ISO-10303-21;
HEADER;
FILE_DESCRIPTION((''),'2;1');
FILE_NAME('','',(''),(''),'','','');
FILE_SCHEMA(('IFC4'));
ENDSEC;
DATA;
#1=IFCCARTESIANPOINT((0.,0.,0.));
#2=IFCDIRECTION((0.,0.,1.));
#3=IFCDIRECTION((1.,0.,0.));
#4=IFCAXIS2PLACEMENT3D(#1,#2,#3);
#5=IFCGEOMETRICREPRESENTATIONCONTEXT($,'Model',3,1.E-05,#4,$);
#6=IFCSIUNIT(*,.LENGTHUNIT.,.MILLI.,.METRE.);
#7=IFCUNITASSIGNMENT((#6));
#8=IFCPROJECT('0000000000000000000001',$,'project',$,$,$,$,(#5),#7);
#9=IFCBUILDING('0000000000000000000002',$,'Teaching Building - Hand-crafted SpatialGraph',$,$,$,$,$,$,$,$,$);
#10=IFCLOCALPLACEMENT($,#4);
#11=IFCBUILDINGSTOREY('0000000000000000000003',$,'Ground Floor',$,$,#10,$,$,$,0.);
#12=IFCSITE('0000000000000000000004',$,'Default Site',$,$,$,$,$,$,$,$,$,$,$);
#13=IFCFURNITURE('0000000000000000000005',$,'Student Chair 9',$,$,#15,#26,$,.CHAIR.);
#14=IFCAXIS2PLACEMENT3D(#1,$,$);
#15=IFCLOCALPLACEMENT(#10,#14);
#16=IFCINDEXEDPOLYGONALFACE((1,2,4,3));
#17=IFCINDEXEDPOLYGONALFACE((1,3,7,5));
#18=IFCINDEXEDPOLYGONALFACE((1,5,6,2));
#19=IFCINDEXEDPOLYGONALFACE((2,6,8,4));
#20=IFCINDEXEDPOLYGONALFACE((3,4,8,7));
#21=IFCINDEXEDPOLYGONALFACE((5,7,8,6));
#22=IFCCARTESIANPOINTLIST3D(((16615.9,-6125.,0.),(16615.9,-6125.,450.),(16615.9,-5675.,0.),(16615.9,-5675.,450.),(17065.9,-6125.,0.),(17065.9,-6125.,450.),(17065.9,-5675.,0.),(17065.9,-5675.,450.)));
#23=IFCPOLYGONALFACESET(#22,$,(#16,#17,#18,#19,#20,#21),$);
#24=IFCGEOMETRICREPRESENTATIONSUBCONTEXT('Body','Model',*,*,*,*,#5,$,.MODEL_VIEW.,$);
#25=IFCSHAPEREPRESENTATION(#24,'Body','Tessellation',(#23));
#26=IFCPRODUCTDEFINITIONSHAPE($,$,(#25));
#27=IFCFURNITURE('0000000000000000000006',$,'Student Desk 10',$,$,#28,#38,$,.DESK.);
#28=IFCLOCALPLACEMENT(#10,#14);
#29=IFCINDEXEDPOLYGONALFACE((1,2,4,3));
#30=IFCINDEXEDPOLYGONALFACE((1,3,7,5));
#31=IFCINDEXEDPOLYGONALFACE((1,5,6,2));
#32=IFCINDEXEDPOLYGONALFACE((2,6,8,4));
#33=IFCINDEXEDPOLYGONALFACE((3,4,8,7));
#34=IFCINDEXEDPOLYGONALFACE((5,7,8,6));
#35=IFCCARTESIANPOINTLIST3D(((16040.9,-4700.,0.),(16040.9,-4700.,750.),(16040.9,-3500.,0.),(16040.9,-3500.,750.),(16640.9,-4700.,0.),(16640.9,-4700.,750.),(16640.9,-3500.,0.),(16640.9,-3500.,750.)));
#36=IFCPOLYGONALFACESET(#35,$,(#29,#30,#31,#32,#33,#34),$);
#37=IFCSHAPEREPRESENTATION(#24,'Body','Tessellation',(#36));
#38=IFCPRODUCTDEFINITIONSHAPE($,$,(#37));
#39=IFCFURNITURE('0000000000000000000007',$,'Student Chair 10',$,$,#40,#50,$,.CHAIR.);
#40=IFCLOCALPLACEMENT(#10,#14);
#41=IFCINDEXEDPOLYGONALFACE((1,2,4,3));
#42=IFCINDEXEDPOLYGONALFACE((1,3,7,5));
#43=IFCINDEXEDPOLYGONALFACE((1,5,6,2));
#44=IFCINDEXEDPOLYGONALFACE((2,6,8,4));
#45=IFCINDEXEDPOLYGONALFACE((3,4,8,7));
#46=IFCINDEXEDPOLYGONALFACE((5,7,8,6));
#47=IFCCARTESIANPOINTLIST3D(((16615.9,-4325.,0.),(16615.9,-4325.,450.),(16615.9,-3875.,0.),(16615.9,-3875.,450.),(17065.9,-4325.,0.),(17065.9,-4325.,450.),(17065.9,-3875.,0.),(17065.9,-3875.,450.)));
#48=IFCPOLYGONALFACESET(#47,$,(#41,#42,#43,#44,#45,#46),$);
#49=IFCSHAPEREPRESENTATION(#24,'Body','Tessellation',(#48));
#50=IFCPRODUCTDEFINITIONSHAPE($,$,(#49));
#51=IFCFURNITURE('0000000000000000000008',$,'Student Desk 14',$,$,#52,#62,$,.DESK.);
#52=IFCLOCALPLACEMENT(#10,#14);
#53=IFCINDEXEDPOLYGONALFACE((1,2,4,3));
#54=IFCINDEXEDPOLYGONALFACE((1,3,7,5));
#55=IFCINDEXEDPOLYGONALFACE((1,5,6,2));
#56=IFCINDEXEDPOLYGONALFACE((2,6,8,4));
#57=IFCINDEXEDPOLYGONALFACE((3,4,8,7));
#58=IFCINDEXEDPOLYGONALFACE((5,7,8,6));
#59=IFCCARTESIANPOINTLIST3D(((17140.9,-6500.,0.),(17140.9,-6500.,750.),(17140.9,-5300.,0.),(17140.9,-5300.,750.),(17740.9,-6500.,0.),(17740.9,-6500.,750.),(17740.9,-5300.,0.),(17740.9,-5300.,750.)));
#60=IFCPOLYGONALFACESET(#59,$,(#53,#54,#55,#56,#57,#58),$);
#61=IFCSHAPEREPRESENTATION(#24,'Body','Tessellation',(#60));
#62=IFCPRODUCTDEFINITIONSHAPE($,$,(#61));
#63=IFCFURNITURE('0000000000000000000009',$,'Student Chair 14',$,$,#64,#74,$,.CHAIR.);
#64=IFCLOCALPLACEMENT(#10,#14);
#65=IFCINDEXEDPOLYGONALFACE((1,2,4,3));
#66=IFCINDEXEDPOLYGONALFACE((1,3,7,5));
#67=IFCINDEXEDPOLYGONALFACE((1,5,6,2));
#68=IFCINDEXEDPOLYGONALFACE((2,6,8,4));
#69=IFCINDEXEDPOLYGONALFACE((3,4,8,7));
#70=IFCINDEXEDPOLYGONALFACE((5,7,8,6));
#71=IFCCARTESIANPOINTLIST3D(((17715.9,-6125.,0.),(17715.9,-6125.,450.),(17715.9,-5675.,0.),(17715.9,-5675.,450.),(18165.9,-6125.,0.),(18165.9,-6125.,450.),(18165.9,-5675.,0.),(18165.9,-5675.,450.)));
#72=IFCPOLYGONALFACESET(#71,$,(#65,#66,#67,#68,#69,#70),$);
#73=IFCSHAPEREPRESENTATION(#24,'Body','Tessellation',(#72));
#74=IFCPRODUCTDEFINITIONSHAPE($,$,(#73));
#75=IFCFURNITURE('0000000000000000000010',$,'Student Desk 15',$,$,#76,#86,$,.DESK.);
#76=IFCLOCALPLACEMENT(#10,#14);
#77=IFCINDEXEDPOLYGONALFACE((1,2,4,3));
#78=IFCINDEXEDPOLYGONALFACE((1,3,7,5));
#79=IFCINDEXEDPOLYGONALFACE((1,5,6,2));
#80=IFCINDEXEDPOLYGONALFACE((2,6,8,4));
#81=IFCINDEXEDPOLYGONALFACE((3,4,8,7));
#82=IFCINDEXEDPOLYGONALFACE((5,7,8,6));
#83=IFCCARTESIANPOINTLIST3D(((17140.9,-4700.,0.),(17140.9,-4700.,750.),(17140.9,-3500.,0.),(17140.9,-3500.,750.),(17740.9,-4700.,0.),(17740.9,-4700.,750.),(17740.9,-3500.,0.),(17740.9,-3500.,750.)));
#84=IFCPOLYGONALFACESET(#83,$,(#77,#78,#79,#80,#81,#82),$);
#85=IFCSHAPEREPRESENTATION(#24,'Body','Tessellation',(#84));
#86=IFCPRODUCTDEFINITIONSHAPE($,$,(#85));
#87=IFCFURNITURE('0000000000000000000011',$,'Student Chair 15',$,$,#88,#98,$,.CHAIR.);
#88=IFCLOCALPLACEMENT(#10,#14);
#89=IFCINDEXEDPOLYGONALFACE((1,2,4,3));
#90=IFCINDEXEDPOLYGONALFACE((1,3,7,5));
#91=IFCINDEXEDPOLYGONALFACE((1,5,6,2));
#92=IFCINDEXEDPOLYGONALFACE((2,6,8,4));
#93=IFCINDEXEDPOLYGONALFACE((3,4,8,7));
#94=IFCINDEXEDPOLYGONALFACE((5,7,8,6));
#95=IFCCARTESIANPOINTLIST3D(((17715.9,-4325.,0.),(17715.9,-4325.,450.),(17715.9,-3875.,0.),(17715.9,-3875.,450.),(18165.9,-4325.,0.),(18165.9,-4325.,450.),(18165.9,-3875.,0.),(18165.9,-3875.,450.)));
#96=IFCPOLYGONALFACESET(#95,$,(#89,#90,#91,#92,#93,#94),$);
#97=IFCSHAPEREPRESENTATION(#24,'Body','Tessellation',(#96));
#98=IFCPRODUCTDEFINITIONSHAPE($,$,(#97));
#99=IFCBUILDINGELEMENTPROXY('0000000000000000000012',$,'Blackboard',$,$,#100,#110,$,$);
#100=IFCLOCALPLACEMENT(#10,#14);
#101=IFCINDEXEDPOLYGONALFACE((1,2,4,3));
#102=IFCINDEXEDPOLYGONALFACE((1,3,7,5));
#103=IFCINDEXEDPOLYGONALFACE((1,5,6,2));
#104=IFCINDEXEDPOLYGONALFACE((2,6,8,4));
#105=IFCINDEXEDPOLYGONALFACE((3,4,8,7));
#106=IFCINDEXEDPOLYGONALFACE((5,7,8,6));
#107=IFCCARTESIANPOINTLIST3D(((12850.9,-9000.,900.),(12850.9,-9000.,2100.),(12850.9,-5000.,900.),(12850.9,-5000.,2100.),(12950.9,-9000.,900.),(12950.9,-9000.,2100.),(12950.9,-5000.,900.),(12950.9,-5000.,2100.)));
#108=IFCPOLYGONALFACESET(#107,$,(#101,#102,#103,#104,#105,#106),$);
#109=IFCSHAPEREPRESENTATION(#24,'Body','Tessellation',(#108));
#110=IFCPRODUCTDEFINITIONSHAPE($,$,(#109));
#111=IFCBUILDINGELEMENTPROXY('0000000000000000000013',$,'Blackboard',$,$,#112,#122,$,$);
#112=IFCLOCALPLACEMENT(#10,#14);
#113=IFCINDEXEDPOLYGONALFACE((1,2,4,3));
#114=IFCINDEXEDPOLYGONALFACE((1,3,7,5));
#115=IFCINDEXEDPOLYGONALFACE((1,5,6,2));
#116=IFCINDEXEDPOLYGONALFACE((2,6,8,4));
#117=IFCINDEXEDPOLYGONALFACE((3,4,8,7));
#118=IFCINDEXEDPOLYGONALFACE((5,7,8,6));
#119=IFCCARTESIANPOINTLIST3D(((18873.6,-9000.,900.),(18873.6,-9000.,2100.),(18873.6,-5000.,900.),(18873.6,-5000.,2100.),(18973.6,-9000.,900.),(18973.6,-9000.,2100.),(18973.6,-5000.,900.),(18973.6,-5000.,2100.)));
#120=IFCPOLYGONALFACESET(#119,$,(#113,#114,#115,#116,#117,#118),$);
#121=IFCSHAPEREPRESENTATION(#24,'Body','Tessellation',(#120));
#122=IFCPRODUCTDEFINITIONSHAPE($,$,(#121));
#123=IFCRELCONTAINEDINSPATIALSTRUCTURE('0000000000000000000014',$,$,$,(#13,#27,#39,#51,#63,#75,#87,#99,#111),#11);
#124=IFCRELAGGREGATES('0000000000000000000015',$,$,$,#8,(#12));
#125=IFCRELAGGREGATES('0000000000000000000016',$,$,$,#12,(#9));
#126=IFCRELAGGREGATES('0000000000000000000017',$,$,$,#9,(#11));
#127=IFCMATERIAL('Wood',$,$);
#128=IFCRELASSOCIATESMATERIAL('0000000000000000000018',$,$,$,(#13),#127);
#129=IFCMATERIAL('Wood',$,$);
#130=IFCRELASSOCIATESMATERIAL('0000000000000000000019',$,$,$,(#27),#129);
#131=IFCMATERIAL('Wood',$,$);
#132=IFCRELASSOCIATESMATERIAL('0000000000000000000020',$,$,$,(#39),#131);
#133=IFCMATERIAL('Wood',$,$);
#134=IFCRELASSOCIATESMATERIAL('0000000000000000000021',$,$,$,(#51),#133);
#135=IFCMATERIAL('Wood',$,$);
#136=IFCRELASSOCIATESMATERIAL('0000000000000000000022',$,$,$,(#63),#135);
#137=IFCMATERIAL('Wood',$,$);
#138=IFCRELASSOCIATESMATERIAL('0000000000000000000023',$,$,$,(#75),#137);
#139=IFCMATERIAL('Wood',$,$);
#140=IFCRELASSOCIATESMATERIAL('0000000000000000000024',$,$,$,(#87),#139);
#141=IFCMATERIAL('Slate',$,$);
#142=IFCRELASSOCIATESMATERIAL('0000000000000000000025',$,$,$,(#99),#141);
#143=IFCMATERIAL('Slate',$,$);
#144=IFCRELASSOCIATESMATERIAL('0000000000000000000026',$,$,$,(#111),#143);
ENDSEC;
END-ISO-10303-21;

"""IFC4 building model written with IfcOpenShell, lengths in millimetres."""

from ifc_helpers import new_model, si_unit, frame, origin_with_axes, origin_2d, place, context, subcontext, project, spatial, rectangle, extrude, material, element, save


model = new_model("IFC4")

# Units and contexts
model_context = context("Model", 3, precision=1e-05, world=origin_with_axes())
body_context = subcontext(model_context, "Body", "Model", "MODEL_VIEW")
ifc_project = project(units=[si_unit("LENGTHUNIT", "METRE", prefix="MILLI")], contexts=[model_context])

# Site, building, storey
site = spatial("IfcSite", under=ifc_project, Name="Default Site")
building = spatial("IfcBuilding", under=site, Name="Teaching Building - Hand-crafted SpatialGraph")
storey_placement = place(None, origin_with_axes())
storey = spatial("IfcBuildingStorey", under=building, at=storey_placement, Name="Ground Floor", Elevation=0.0)

# Furniture
ifc_material_1 = material(Name="Wood")
furniture_1_placement = place(storey_placement, frame((16840.9, -5900.0, 0.0), z_axis=(0.0, 0.0, 1.0), x_axis=(1.0, 0.0, 0.0)))
element("IfcFurniture", 1, at=furniture_1_placement, inside=storey, material=ifc_material_1, Name="Student Chair 9", PredefinedType="CHAIR", context=body_context, shape_type="SweptSolid", body=[
    extrude(rectangle(XDim=450.0, YDim=450.0, at=origin_2d()), origin_with_axes(), (0.0, 0.0, 1.0), 450.0),
])
ifc_material_2 = material(Name="Wood")
furniture_2_placement = place(storey_placement, frame((16340.9, -4100.0, 0.0), z_axis=(0.0, 0.0, 1.0), x_axis=(0.0, 1.0, 0.0)))
element("IfcFurniture", 2, at=furniture_2_placement, inside=storey, material=ifc_material_2, Name="Student Desk 10", PredefinedType="DESK", context=body_context, shape_type="SweptSolid", body=[
    extrude(rectangle(XDim=1200.0, YDim=600.0, at=origin_2d()), origin_with_axes(), (0.0, 0.0, 1.0), 750.0),
])
ifc_material_3 = material(Name="Wood")
furniture_3_placement = place(storey_placement, frame((16840.9, -4100.0, 0.0), z_axis=(0.0, 0.0, 1.0), x_axis=(1.0, 0.0, 0.0)))
element("IfcFurniture", 3, at=furniture_3_placement, inside=storey, material=ifc_material_3, Name="Student Chair 10", PredefinedType="CHAIR", context=body_context, shape_type="SweptSolid", body=[
    extrude(rectangle(XDim=450.0, YDim=450.0, at=origin_2d()), origin_with_axes(), (0.0, 0.0, 1.0), 450.0),
])
ifc_material_4 = material(Name="Wood")
furniture_4_placement = place(storey_placement, frame((17440.9, -5900.0, 0.0), z_axis=(0.0, 0.0, 1.0), x_axis=(0.0, 1.0, 0.0)))
element("IfcFurniture", 4, at=furniture_4_placement, inside=storey, material=ifc_material_4, Name="Student Desk 14", PredefinedType="DESK", context=body_context, shape_type="SweptSolid", body=[
    extrude(rectangle(XDim=1200.0, YDim=600.0, at=origin_2d()), origin_with_axes(), (0.0, 0.0, 1.0), 750.0),
])
ifc_material_5 = material(Name="Wood")
furniture_5_placement = place(storey_placement, frame((17940.9, -5900.0, 0.0), z_axis=(0.0, 0.0, 1.0), x_axis=(1.0, 0.0, 0.0)))
element("IfcFurniture", 5, at=furniture_5_placement, inside=storey, material=ifc_material_5, Name="Student Chair 14", PredefinedType="CHAIR", context=body_context, shape_type="SweptSolid", body=[
    extrude(rectangle(XDim=450.0, YDim=450.0, at=origin_2d()), origin_with_axes(), (0.0, 0.0, 1.0), 450.0),
])
ifc_material_6 = material(Name="Wood")
furniture_6_placement = place(storey_placement, frame((17440.9, -4100.0, 0.0), z_axis=(0.0, 0.0, 1.0), x_axis=(0.0, 1.0, 0.0)))
element("IfcFurniture", 6, at=furniture_6_placement, inside=storey, material=ifc_material_6, Name="Student Desk 15", PredefinedType="DESK", context=body_context, shape_type="SweptSolid", body=[
    extrude(rectangle(XDim=1200.0, YDim=600.0, at=origin_2d()), origin_with_axes(), (0.0, 0.0, 1.0), 750.0),
])
ifc_material_7 = material(Name="Wood")
furniture_7_placement = place(storey_placement, frame((17940.9, -4100.0, 0.0), z_axis=(0.0, 0.0, 1.0), x_axis=(1.0, 0.0, 0.0)))
element("IfcFurniture", 7, at=furniture_7_placement, inside=storey, material=ifc_material_7, Name="Student Chair 15", PredefinedType="CHAIR", context=body_context, shape_type="SweptSolid", body=[
    extrude(rectangle(XDim=450.0, YDim=450.0, at=origin_2d()), origin_with_axes(), (0.0, 0.0, 1.0), 450.0),
])

# Building element proxies
ifc_material_8 = material(Name="Slate")
proxy_1_placement = place(storey_placement, frame((12900.9, -7000.0, 900.0), z_axis=(0.0, 0.0, 1.0), x_axis=(1.0, 0.0, 0.0)))
element("IfcBuildingElementProxy", 8, at=proxy_1_placement, inside=storey, material=ifc_material_8, Name="Blackboard", context=body_context, shape_type="SweptSolid", body=[
    extrude(rectangle(XDim=100.0, YDim=4000.0, at=origin_2d()), origin_with_axes(), (0.0, 0.0, 1.0), 1200.0),
])
ifc_material_9 = material(Name="Slate")
proxy_2_placement = place(storey_placement, frame((18923.6, -7000.0, 900.0), z_axis=(0.0, 0.0, 1.0), x_axis=(1.0, 0.0, 0.0)))
element("IfcBuildingElementProxy", 9, at=proxy_2_placement, inside=storey, material=ifc_material_9, Name="Blackboard", context=body_context, shape_type="SweptSolid", body=[
    extrude(rectangle(XDim=100.0, YDim=4000.0, at=origin_2d()), origin_with_axes(), (0.0, 0.0, 1.0), 1200.0),
])

save(model, "model.ifc")
